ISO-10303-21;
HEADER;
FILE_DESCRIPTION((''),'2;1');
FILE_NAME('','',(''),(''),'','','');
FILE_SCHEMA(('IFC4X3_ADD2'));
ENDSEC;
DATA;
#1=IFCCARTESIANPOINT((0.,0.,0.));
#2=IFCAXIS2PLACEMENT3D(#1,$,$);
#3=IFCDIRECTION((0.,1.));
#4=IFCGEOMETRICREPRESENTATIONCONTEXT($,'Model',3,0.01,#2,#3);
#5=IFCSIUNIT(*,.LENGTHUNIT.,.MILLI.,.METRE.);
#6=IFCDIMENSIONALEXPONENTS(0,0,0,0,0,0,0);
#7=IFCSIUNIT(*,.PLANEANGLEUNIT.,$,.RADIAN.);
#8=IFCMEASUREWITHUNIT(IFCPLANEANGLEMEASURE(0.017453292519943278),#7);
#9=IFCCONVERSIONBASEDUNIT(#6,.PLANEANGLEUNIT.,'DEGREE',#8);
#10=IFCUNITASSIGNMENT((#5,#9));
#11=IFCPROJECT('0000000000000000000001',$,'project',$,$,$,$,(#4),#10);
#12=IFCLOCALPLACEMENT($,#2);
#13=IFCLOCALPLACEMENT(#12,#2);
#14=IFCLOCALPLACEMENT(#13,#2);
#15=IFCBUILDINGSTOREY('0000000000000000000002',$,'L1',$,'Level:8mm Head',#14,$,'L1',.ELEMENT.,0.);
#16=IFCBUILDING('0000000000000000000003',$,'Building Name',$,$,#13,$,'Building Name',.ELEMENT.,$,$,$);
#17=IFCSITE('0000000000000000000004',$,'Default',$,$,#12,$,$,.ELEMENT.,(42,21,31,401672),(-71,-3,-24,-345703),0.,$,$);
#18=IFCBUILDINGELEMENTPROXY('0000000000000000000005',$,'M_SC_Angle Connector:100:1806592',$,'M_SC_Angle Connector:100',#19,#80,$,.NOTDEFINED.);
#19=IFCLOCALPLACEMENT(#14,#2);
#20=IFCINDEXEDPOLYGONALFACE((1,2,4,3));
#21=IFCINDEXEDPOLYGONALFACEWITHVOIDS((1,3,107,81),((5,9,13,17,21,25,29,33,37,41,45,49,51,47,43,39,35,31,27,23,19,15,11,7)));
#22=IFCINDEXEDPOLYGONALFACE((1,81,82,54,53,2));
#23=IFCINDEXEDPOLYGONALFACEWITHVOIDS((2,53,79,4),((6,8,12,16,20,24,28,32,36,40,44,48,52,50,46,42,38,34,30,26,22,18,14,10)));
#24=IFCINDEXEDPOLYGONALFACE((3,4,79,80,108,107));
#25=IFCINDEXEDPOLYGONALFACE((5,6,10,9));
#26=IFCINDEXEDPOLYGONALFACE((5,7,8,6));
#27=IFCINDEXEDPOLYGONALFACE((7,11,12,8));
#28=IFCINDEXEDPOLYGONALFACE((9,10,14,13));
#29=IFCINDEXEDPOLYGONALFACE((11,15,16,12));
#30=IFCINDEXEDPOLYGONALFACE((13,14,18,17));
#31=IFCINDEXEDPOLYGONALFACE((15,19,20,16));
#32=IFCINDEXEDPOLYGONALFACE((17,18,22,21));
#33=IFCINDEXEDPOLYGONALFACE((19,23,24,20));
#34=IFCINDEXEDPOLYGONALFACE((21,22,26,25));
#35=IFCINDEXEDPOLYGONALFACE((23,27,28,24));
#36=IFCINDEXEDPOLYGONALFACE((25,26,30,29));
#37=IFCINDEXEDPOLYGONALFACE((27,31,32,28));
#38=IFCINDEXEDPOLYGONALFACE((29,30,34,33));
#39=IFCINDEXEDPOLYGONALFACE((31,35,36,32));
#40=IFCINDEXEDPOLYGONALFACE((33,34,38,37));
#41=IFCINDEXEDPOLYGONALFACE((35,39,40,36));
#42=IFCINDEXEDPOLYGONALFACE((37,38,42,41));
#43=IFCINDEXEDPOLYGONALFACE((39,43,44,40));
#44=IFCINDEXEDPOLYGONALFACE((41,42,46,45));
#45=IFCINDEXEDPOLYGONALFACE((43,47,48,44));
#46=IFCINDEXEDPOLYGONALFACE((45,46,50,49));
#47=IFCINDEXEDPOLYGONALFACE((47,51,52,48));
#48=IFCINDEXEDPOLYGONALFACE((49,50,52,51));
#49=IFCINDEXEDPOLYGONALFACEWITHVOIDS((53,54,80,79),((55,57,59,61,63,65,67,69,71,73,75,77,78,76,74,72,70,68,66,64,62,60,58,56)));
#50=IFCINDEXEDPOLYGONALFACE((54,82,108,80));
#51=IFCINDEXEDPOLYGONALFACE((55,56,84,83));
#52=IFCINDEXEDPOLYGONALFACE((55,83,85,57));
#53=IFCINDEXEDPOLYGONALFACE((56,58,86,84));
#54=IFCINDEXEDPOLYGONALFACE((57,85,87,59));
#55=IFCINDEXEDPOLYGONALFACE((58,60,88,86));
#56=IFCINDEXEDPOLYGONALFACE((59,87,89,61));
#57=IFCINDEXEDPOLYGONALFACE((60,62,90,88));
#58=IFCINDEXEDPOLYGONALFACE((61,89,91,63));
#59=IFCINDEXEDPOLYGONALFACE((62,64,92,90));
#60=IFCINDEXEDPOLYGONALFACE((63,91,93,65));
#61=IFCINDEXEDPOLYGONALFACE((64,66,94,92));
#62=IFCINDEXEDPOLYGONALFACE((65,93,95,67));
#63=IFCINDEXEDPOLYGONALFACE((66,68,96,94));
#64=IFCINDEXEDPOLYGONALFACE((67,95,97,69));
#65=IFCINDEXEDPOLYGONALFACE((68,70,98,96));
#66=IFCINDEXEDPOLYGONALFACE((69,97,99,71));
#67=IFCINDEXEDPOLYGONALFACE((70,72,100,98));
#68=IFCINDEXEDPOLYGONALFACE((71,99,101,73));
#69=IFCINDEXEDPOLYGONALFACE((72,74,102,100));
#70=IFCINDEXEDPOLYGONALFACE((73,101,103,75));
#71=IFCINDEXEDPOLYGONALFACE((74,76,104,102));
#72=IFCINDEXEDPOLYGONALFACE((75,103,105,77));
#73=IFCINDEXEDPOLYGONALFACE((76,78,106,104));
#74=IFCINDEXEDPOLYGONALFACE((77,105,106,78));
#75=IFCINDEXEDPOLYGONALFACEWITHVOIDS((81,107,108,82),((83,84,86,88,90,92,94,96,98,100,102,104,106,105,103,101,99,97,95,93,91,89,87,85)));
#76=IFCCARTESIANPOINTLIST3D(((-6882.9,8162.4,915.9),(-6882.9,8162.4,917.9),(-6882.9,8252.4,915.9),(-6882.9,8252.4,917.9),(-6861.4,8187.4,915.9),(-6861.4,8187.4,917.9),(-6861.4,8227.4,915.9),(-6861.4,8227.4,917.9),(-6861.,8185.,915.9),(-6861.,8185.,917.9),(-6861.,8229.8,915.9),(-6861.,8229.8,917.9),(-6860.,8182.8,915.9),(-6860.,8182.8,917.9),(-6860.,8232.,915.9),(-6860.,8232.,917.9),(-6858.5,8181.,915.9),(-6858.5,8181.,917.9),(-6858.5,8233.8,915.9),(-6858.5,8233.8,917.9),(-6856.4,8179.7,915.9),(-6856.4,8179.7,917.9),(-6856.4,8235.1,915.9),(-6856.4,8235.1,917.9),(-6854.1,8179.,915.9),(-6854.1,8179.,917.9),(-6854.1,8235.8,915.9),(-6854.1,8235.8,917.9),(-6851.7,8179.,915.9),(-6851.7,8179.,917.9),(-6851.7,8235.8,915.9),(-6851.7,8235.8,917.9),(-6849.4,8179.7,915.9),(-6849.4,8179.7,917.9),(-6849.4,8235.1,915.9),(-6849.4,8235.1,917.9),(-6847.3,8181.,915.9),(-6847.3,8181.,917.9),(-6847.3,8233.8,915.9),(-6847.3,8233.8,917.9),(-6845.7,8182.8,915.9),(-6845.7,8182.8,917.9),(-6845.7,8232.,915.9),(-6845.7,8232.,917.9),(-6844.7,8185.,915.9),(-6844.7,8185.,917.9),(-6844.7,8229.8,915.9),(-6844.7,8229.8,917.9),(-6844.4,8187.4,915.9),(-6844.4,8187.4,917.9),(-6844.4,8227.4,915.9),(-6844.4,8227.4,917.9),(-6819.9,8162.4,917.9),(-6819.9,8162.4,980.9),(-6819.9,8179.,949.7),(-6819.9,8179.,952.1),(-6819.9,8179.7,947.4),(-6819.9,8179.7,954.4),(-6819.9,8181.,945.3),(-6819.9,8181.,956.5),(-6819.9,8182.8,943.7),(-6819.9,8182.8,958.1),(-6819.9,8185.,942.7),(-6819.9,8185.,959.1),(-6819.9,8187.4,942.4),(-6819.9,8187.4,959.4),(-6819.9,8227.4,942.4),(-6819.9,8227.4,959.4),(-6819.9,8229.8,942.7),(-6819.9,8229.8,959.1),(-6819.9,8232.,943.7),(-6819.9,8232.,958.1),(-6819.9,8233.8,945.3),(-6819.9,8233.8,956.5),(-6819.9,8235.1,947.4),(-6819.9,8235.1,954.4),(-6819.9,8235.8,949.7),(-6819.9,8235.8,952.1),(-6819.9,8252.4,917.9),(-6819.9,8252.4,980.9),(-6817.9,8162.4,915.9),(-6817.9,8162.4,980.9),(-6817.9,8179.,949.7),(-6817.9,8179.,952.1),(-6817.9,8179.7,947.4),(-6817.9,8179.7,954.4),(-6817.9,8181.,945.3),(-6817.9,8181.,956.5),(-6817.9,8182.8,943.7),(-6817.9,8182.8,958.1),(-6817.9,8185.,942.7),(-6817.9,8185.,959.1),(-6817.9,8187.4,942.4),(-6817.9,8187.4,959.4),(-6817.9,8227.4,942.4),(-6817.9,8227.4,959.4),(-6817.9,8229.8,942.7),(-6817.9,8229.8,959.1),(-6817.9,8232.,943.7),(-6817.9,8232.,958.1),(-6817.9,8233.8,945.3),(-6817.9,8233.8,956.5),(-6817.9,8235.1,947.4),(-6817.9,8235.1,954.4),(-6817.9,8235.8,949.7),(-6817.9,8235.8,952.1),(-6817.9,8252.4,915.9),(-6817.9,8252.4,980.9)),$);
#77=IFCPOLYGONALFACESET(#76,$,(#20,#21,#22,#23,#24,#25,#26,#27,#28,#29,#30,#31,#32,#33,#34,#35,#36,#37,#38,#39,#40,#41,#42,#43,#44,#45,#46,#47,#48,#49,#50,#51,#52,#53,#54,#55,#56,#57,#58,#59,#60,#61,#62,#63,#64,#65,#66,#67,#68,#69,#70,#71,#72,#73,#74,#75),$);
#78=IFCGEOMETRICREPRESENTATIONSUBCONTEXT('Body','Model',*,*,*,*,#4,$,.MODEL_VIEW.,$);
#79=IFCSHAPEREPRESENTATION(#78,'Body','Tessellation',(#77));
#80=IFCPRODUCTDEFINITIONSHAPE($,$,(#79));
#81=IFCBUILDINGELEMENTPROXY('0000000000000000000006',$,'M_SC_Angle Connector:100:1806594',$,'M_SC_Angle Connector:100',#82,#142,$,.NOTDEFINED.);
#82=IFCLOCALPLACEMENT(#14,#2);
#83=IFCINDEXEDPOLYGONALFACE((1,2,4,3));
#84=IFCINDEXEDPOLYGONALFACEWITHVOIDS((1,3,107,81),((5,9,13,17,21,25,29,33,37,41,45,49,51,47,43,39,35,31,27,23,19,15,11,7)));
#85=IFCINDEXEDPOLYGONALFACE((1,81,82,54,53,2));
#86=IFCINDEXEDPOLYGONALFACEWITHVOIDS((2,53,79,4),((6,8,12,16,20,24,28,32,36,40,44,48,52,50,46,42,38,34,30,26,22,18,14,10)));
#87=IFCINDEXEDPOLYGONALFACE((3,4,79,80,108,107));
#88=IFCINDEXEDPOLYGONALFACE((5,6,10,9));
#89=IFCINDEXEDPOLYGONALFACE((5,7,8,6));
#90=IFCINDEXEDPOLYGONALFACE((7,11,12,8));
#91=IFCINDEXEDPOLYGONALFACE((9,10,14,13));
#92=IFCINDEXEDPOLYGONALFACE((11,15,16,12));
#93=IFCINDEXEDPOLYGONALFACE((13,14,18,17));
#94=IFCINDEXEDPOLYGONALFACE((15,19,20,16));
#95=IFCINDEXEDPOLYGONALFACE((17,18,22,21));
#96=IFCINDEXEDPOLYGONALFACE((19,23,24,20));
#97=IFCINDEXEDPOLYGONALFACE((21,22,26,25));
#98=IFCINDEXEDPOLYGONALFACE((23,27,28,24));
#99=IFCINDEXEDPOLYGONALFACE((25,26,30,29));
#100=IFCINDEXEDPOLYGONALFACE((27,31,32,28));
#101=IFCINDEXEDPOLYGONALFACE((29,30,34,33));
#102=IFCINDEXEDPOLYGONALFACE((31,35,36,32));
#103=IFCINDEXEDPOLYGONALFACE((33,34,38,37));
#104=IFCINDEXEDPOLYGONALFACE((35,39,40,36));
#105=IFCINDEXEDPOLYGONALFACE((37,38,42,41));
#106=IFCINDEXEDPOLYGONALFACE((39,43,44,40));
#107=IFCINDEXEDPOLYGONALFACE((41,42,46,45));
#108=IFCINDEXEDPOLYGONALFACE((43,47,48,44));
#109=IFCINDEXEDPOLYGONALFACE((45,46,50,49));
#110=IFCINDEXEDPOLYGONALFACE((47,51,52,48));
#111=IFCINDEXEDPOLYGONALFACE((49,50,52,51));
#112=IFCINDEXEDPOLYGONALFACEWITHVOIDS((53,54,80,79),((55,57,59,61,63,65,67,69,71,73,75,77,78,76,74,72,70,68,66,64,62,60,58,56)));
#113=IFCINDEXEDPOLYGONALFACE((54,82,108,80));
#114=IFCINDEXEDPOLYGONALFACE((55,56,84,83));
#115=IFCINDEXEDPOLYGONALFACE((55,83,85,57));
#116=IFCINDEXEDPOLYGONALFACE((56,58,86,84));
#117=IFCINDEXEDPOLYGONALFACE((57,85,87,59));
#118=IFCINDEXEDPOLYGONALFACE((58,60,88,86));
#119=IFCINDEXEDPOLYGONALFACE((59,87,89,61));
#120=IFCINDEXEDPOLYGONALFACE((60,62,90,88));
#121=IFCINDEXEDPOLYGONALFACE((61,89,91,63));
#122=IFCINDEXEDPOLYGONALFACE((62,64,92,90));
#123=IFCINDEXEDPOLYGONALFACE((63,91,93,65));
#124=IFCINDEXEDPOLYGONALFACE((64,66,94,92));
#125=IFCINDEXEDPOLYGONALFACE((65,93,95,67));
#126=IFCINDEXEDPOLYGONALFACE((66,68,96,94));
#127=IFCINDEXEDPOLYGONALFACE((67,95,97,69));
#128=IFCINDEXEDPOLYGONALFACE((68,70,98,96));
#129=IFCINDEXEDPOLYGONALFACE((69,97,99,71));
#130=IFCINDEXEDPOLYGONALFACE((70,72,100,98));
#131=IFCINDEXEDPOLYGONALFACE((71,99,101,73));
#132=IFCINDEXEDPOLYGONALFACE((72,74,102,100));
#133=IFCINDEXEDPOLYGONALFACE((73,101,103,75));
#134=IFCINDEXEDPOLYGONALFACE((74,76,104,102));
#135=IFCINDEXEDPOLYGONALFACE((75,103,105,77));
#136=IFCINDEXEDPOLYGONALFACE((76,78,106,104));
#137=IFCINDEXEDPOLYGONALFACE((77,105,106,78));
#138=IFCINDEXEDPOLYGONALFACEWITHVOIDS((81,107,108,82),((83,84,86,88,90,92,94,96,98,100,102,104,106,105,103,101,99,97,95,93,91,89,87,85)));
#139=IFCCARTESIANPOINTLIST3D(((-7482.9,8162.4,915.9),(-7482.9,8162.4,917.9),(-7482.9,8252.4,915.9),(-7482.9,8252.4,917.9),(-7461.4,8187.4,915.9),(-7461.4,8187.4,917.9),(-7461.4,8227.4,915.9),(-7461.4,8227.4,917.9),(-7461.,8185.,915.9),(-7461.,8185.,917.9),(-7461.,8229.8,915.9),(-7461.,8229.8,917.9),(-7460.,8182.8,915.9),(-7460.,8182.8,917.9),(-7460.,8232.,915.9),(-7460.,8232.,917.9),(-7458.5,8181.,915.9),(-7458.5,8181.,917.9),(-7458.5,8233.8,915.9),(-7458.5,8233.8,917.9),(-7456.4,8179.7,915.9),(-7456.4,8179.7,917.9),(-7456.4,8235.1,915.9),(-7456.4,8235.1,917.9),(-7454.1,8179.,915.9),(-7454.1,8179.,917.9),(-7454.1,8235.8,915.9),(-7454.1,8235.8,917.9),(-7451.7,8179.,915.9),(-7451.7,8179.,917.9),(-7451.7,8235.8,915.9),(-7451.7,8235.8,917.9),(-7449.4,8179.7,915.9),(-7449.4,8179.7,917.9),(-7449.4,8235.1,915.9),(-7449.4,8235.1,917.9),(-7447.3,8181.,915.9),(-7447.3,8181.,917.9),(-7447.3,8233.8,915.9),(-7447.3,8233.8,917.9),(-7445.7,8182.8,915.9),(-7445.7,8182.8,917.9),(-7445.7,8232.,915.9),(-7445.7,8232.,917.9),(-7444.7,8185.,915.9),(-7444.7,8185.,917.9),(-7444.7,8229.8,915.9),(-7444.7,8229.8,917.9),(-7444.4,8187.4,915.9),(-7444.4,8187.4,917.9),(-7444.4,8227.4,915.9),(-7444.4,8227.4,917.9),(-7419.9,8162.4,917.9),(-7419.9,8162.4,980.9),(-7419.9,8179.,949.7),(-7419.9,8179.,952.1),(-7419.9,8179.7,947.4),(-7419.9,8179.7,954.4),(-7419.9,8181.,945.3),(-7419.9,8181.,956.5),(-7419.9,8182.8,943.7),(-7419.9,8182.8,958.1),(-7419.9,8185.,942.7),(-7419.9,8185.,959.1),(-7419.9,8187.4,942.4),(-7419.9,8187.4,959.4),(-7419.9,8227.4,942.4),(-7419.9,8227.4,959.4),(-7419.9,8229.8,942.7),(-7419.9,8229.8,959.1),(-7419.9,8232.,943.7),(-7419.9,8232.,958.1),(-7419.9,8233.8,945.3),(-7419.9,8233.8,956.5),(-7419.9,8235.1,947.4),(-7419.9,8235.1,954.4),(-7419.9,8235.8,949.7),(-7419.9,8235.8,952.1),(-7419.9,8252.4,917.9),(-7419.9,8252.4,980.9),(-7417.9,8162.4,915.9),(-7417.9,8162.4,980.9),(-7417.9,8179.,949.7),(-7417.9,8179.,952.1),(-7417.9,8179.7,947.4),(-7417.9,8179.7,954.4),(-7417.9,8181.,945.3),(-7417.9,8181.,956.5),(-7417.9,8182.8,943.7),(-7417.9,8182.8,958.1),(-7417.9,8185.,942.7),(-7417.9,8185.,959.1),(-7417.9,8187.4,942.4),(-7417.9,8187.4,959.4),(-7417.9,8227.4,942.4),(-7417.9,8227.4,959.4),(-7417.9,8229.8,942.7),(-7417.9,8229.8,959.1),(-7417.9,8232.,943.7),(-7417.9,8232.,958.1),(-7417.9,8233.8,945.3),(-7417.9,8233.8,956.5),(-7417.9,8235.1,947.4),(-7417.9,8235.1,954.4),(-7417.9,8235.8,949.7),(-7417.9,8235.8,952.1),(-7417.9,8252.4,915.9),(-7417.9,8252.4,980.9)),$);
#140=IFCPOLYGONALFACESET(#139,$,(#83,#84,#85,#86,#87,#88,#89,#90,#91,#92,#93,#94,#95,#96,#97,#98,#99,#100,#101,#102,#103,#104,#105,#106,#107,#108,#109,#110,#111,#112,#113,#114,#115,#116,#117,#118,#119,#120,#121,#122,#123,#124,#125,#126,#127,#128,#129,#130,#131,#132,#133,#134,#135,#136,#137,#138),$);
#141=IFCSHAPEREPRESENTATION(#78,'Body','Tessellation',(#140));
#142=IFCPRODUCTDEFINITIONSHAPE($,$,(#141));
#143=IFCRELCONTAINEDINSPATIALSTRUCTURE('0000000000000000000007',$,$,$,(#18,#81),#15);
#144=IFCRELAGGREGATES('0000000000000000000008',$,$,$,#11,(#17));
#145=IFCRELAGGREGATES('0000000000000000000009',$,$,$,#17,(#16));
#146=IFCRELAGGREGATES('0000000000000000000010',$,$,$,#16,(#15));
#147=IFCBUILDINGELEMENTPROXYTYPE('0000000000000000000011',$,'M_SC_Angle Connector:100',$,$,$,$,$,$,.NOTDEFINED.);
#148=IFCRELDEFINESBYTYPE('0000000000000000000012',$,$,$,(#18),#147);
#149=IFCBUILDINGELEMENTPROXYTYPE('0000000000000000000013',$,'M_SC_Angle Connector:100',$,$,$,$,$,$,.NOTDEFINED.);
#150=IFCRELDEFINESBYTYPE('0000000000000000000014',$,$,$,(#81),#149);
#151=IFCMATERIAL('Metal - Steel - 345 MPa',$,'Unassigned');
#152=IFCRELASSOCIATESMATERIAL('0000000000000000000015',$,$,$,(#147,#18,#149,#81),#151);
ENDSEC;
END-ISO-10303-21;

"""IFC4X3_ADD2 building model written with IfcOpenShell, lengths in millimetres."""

from ifc_helpers import new_model, entity, si_unit, converted_unit, direction, frame, frame_2d, origin, place, context, subcontext, project, spatial, polyline, circle_curve, parameter, trimmed, segment, composite_curve, outline, extrude, source, transform, mapped, material, type_object, type_shapes, element, save


model = new_model("IFC4X3_ADD2")

# Units and contexts
model_context = context("Model", 3, precision=0.01, world=origin(), true_north=direction((0.0, 1.0)))
body_context = subcontext(model_context, "Body", "Model", "MODEL_VIEW")
ifc_project = project(units=[si_unit("LENGTHUNIT", "METRE", prefix="MILLI"), converted_unit("PLANEANGLEUNIT", "DEGREE", entity("IfcPlaneAngleMeasure", 0.017453292519943278), si_unit("PLANEANGLEUNIT", "RADIAN"), dimensions=[0, 0, 0, 0, 0, 0, 0])], contexts=[model_context])

# Site, building, storey
site_placement = place(None, origin())
site = spatial("IfcSite", under=ifc_project, at=site_placement, Name="Default", CompositionType="ELEMENT", RefLatitude=(42, 21, 31, 401672), RefLongitude=(-71, -3, -24, -345703), RefElevation=0.0)
building_placement = place(site_placement, origin())
building = spatial("IfcBuilding", under=site, at=building_placement, Name="Building Name", LongName="Building Name", CompositionType="ELEMENT")
storey_placement = place(building_placement, origin())
storey = spatial("IfcBuildingStorey", under=building, at=storey_placement, Name="L1", ObjectType="Level:8mm Head", LongName="L1", CompositionType="ELEMENT", Elevation=0.0)

# Building element proxies, openings
ifc_material_1 = material(Name="Metal - Steel - 345 MPa", Category="Unassigned")
building_element_proxy_type_1 = type_object("IfcBuildingElementProxyType", Name="M_SC_Angle Connector:100", PredefinedType="NOTDEFINED", material=ifc_material_1)
shared_shape_1 = source(origin(), body_context, "Body", "SweptSolid", [
    extrude(outline(polyline([(-42.7, -22.3), (22.3, -22.3), (22.3, 42.7), (20.3, 42.7), (20.3, -20.3), (-42.7, -20.3), (-42.7, -22.3)])), frame((22.3, -45.0, 22.3), z_axis=(0.0, 1.0, 0.0), x_axis=(-1.0, 0.0, 0.0)), (0.0, 0.0, 1.0), 90.0),
])
type_shapes(building_element_proxy_type_1, [shared_shape_1])
proxy_1_placement = place(storey_placement, frame((-6817.9, 8207.4, 915.9), z_axis=(0.0, 0.0, 1.0), x_axis=(-1.0, 0.0, 0.0)))
proxy_1 = element("IfcBuildingElementProxy", 1, at=proxy_1_placement, inside=storey, type_object=building_element_proxy_type_1, material=ifc_material_1, Name="M_SC_Angle Connector:100:1806592", ObjectType="M_SC_Angle Connector:100", PredefinedType="NOTDEFINED", context=body_context, shape_type="MappedRepresentation", body=[
    mapped(shared_shape_1, transform((0.0, 0.0, 0.0), scale=1.0)),
])
opening_1_placement = place(storey_placement, frame((-6817.9, 8207.4, 915.9)))
element("IfcOpeningElement", 2, at=opening_1_placement, cuts=proxy_1, PredefinedType="OPENING", context=body_context, shape_type="SweptSolid", body=[
    extrude(outline(composite_curve([segment(polyline([(-20.0, -8.5), (20.0, -8.5)]), True, "CONTINUOUS"), segment(trimmed(circle_curve(frame_2d((20.0, 0.0), x_axis=(0.0, 1.0)), 8.5), [parameter(180.0)], [parameter(360.0)], True, "PARAMETER"), True, "CONTINUOUS"), segment(polyline([(20.0, 8.5), (-20.0, 8.5)]), True, "CONTINUOUS"), segment(trimmed(circle_curve(frame_2d((-20.0, 0.0), x_axis=(0.0, 1.0)), 8.5), [parameter(360.0)], [parameter(180.0)], True, "PARAMETER"), True, "CONTINUOUS")], self_intersect=False)), frame((-2.0, 0.0, 35.0), z_axis=(1.0, 0.0, 0.0), x_axis=(0.0, 1.0, 0.0)), (0.0, 0.0, 1.0), 2.0),
])
opening_2_placement = place(storey_placement, frame((-6817.9, 8207.4, 915.9)))
element("IfcOpeningElement", 3, at=opening_2_placement, cuts=proxy_1, PredefinedType="OPENING", context=body_context, shape_type="SweptSolid", body=[
    extrude(outline(composite_curve([segment(polyline([(-20.0, -8.5), (20.0, -8.5)]), True, "CONTINUOUS"), segment(trimmed(circle_curve(frame_2d((20.0, 0.0), x_axis=(0.0, -1.0)), 8.5), [parameter(360.0)], [parameter(180.0)], True, "PARAMETER"), True, "CONTINUOUS"), segment(polyline([(20.0, 8.5), (-20.0, 8.5)]), True, "CONTINUOUS"), segment(trimmed(circle_curve(frame_2d((-20.0, 0.0), x_axis=(0.0, -1.0)), 8.5), [parameter(180.0)], [parameter(360.0)], True, "PARAMETER"), True, "CONTINUOUS")], self_intersect=False)), frame((-35.0, 0.0, 2.0), z_axis=(0.0, 0.0, -1.0), x_axis=(0.0, 1.0, 0.0)), (0.0, 0.0, 1.0), 2.0),
])
building_element_proxy_type_2 = type_object("IfcBuildingElementProxyType", Name="M_SC_Angle Connector:100", PredefinedType="NOTDEFINED", material=ifc_material_1)
shared_shape_2 = source(origin(), body_context, "Body", "SweptSolid", [
    extrude(outline(polyline([(-42.7, -22.3), (22.3, -22.3), (22.3, 42.7), (20.3, 42.7), (20.3, -20.3), (-42.7, -20.3), (-42.7, -22.3)])), frame((22.3, -45.0, 22.3), z_axis=(0.0, 1.0, 0.0), x_axis=(-1.0, 0.0, 0.0)), (0.0, 0.0, 1.0), 90.0),
])
type_shapes(building_element_proxy_type_2, [shared_shape_2])
proxy_2_placement = place(storey_placement, frame((-7417.9, 8207.4, 915.9), z_axis=(0.0, 0.0, 1.0), x_axis=(-1.0, 0.0, 0.0)))
proxy_2 = element("IfcBuildingElementProxy", 4, at=proxy_2_placement, inside=storey, type_object=building_element_proxy_type_2, material=ifc_material_1, Name="M_SC_Angle Connector:100:1806594", ObjectType="M_SC_Angle Connector:100", PredefinedType="NOTDEFINED", context=body_context, shape_type="MappedRepresentation", body=[
    mapped(shared_shape_2, transform((0.0, 0.0, 0.0), scale=1.0)),
])
opening_3_placement = place(storey_placement, frame((-7417.9, 8207.4, 915.9)))
element("IfcOpeningElement", 5, at=opening_3_placement, cuts=proxy_2, PredefinedType="OPENING", context=body_context, shape_type="SweptSolid", body=[
    extrude(outline(composite_curve([segment(polyline([(-20.0, -8.5), (20.0, -8.5)]), True, "CONTINUOUS"), segment(trimmed(circle_curve(frame_2d((20.0, 0.0), x_axis=(0.0, 1.0)), 8.5), [parameter(180.0)], [parameter(360.0)], True, "PARAMETER"), True, "CONTINUOUS"), segment(polyline([(20.0, 8.5), (-20.0, 8.5)]), True, "CONTINUOUS"), segment(trimmed(circle_curve(frame_2d((-20.0, 0.0), x_axis=(0.0, 1.0)), 8.5), [parameter(360.0)], [parameter(180.0)], True, "PARAMETER"), True, "CONTINUOUS")], self_intersect=False)), frame((-2.0, 0.0, 35.0), z_axis=(1.0, 0.0, 0.0), x_axis=(0.0, 1.0, 0.0)), (0.0, 0.0, 1.0), 2.0),
])
opening_4_placement = place(storey_placement, frame((-7417.9, 8207.4, 915.9)))
element("IfcOpeningElement", 6, at=opening_4_placement, cuts=proxy_2, PredefinedType="OPENING", context=body_context, shape_type="SweptSolid", body=[
    extrude(outline(composite_curve([segment(polyline([(-20.0, -8.5), (20.0, -8.5)]), True, "CONTINUOUS"), segment(trimmed(circle_curve(frame_2d((20.0, 0.0), x_axis=(0.0, -1.0)), 8.5), [parameter(360.0)], [parameter(180.0)], True, "PARAMETER"), True, "CONTINUOUS"), segment(polyline([(20.0, 8.5), (-20.0, 8.5)]), True, "CONTINUOUS"), segment(trimmed(circle_curve(frame_2d((-20.0, 0.0), x_axis=(0.0, -1.0)), 8.5), [parameter(180.0)], [parameter(360.0)], True, "PARAMETER"), True, "CONTINUOUS")], self_intersect=False)), frame((-35.0, 0.0, 2.0), z_axis=(0.0, 0.0, -1.0), x_axis=(0.0, 1.0, 0.0)), (0.0, 0.0, 1.0), 2.0),
])

save(model, "model.ifc")
